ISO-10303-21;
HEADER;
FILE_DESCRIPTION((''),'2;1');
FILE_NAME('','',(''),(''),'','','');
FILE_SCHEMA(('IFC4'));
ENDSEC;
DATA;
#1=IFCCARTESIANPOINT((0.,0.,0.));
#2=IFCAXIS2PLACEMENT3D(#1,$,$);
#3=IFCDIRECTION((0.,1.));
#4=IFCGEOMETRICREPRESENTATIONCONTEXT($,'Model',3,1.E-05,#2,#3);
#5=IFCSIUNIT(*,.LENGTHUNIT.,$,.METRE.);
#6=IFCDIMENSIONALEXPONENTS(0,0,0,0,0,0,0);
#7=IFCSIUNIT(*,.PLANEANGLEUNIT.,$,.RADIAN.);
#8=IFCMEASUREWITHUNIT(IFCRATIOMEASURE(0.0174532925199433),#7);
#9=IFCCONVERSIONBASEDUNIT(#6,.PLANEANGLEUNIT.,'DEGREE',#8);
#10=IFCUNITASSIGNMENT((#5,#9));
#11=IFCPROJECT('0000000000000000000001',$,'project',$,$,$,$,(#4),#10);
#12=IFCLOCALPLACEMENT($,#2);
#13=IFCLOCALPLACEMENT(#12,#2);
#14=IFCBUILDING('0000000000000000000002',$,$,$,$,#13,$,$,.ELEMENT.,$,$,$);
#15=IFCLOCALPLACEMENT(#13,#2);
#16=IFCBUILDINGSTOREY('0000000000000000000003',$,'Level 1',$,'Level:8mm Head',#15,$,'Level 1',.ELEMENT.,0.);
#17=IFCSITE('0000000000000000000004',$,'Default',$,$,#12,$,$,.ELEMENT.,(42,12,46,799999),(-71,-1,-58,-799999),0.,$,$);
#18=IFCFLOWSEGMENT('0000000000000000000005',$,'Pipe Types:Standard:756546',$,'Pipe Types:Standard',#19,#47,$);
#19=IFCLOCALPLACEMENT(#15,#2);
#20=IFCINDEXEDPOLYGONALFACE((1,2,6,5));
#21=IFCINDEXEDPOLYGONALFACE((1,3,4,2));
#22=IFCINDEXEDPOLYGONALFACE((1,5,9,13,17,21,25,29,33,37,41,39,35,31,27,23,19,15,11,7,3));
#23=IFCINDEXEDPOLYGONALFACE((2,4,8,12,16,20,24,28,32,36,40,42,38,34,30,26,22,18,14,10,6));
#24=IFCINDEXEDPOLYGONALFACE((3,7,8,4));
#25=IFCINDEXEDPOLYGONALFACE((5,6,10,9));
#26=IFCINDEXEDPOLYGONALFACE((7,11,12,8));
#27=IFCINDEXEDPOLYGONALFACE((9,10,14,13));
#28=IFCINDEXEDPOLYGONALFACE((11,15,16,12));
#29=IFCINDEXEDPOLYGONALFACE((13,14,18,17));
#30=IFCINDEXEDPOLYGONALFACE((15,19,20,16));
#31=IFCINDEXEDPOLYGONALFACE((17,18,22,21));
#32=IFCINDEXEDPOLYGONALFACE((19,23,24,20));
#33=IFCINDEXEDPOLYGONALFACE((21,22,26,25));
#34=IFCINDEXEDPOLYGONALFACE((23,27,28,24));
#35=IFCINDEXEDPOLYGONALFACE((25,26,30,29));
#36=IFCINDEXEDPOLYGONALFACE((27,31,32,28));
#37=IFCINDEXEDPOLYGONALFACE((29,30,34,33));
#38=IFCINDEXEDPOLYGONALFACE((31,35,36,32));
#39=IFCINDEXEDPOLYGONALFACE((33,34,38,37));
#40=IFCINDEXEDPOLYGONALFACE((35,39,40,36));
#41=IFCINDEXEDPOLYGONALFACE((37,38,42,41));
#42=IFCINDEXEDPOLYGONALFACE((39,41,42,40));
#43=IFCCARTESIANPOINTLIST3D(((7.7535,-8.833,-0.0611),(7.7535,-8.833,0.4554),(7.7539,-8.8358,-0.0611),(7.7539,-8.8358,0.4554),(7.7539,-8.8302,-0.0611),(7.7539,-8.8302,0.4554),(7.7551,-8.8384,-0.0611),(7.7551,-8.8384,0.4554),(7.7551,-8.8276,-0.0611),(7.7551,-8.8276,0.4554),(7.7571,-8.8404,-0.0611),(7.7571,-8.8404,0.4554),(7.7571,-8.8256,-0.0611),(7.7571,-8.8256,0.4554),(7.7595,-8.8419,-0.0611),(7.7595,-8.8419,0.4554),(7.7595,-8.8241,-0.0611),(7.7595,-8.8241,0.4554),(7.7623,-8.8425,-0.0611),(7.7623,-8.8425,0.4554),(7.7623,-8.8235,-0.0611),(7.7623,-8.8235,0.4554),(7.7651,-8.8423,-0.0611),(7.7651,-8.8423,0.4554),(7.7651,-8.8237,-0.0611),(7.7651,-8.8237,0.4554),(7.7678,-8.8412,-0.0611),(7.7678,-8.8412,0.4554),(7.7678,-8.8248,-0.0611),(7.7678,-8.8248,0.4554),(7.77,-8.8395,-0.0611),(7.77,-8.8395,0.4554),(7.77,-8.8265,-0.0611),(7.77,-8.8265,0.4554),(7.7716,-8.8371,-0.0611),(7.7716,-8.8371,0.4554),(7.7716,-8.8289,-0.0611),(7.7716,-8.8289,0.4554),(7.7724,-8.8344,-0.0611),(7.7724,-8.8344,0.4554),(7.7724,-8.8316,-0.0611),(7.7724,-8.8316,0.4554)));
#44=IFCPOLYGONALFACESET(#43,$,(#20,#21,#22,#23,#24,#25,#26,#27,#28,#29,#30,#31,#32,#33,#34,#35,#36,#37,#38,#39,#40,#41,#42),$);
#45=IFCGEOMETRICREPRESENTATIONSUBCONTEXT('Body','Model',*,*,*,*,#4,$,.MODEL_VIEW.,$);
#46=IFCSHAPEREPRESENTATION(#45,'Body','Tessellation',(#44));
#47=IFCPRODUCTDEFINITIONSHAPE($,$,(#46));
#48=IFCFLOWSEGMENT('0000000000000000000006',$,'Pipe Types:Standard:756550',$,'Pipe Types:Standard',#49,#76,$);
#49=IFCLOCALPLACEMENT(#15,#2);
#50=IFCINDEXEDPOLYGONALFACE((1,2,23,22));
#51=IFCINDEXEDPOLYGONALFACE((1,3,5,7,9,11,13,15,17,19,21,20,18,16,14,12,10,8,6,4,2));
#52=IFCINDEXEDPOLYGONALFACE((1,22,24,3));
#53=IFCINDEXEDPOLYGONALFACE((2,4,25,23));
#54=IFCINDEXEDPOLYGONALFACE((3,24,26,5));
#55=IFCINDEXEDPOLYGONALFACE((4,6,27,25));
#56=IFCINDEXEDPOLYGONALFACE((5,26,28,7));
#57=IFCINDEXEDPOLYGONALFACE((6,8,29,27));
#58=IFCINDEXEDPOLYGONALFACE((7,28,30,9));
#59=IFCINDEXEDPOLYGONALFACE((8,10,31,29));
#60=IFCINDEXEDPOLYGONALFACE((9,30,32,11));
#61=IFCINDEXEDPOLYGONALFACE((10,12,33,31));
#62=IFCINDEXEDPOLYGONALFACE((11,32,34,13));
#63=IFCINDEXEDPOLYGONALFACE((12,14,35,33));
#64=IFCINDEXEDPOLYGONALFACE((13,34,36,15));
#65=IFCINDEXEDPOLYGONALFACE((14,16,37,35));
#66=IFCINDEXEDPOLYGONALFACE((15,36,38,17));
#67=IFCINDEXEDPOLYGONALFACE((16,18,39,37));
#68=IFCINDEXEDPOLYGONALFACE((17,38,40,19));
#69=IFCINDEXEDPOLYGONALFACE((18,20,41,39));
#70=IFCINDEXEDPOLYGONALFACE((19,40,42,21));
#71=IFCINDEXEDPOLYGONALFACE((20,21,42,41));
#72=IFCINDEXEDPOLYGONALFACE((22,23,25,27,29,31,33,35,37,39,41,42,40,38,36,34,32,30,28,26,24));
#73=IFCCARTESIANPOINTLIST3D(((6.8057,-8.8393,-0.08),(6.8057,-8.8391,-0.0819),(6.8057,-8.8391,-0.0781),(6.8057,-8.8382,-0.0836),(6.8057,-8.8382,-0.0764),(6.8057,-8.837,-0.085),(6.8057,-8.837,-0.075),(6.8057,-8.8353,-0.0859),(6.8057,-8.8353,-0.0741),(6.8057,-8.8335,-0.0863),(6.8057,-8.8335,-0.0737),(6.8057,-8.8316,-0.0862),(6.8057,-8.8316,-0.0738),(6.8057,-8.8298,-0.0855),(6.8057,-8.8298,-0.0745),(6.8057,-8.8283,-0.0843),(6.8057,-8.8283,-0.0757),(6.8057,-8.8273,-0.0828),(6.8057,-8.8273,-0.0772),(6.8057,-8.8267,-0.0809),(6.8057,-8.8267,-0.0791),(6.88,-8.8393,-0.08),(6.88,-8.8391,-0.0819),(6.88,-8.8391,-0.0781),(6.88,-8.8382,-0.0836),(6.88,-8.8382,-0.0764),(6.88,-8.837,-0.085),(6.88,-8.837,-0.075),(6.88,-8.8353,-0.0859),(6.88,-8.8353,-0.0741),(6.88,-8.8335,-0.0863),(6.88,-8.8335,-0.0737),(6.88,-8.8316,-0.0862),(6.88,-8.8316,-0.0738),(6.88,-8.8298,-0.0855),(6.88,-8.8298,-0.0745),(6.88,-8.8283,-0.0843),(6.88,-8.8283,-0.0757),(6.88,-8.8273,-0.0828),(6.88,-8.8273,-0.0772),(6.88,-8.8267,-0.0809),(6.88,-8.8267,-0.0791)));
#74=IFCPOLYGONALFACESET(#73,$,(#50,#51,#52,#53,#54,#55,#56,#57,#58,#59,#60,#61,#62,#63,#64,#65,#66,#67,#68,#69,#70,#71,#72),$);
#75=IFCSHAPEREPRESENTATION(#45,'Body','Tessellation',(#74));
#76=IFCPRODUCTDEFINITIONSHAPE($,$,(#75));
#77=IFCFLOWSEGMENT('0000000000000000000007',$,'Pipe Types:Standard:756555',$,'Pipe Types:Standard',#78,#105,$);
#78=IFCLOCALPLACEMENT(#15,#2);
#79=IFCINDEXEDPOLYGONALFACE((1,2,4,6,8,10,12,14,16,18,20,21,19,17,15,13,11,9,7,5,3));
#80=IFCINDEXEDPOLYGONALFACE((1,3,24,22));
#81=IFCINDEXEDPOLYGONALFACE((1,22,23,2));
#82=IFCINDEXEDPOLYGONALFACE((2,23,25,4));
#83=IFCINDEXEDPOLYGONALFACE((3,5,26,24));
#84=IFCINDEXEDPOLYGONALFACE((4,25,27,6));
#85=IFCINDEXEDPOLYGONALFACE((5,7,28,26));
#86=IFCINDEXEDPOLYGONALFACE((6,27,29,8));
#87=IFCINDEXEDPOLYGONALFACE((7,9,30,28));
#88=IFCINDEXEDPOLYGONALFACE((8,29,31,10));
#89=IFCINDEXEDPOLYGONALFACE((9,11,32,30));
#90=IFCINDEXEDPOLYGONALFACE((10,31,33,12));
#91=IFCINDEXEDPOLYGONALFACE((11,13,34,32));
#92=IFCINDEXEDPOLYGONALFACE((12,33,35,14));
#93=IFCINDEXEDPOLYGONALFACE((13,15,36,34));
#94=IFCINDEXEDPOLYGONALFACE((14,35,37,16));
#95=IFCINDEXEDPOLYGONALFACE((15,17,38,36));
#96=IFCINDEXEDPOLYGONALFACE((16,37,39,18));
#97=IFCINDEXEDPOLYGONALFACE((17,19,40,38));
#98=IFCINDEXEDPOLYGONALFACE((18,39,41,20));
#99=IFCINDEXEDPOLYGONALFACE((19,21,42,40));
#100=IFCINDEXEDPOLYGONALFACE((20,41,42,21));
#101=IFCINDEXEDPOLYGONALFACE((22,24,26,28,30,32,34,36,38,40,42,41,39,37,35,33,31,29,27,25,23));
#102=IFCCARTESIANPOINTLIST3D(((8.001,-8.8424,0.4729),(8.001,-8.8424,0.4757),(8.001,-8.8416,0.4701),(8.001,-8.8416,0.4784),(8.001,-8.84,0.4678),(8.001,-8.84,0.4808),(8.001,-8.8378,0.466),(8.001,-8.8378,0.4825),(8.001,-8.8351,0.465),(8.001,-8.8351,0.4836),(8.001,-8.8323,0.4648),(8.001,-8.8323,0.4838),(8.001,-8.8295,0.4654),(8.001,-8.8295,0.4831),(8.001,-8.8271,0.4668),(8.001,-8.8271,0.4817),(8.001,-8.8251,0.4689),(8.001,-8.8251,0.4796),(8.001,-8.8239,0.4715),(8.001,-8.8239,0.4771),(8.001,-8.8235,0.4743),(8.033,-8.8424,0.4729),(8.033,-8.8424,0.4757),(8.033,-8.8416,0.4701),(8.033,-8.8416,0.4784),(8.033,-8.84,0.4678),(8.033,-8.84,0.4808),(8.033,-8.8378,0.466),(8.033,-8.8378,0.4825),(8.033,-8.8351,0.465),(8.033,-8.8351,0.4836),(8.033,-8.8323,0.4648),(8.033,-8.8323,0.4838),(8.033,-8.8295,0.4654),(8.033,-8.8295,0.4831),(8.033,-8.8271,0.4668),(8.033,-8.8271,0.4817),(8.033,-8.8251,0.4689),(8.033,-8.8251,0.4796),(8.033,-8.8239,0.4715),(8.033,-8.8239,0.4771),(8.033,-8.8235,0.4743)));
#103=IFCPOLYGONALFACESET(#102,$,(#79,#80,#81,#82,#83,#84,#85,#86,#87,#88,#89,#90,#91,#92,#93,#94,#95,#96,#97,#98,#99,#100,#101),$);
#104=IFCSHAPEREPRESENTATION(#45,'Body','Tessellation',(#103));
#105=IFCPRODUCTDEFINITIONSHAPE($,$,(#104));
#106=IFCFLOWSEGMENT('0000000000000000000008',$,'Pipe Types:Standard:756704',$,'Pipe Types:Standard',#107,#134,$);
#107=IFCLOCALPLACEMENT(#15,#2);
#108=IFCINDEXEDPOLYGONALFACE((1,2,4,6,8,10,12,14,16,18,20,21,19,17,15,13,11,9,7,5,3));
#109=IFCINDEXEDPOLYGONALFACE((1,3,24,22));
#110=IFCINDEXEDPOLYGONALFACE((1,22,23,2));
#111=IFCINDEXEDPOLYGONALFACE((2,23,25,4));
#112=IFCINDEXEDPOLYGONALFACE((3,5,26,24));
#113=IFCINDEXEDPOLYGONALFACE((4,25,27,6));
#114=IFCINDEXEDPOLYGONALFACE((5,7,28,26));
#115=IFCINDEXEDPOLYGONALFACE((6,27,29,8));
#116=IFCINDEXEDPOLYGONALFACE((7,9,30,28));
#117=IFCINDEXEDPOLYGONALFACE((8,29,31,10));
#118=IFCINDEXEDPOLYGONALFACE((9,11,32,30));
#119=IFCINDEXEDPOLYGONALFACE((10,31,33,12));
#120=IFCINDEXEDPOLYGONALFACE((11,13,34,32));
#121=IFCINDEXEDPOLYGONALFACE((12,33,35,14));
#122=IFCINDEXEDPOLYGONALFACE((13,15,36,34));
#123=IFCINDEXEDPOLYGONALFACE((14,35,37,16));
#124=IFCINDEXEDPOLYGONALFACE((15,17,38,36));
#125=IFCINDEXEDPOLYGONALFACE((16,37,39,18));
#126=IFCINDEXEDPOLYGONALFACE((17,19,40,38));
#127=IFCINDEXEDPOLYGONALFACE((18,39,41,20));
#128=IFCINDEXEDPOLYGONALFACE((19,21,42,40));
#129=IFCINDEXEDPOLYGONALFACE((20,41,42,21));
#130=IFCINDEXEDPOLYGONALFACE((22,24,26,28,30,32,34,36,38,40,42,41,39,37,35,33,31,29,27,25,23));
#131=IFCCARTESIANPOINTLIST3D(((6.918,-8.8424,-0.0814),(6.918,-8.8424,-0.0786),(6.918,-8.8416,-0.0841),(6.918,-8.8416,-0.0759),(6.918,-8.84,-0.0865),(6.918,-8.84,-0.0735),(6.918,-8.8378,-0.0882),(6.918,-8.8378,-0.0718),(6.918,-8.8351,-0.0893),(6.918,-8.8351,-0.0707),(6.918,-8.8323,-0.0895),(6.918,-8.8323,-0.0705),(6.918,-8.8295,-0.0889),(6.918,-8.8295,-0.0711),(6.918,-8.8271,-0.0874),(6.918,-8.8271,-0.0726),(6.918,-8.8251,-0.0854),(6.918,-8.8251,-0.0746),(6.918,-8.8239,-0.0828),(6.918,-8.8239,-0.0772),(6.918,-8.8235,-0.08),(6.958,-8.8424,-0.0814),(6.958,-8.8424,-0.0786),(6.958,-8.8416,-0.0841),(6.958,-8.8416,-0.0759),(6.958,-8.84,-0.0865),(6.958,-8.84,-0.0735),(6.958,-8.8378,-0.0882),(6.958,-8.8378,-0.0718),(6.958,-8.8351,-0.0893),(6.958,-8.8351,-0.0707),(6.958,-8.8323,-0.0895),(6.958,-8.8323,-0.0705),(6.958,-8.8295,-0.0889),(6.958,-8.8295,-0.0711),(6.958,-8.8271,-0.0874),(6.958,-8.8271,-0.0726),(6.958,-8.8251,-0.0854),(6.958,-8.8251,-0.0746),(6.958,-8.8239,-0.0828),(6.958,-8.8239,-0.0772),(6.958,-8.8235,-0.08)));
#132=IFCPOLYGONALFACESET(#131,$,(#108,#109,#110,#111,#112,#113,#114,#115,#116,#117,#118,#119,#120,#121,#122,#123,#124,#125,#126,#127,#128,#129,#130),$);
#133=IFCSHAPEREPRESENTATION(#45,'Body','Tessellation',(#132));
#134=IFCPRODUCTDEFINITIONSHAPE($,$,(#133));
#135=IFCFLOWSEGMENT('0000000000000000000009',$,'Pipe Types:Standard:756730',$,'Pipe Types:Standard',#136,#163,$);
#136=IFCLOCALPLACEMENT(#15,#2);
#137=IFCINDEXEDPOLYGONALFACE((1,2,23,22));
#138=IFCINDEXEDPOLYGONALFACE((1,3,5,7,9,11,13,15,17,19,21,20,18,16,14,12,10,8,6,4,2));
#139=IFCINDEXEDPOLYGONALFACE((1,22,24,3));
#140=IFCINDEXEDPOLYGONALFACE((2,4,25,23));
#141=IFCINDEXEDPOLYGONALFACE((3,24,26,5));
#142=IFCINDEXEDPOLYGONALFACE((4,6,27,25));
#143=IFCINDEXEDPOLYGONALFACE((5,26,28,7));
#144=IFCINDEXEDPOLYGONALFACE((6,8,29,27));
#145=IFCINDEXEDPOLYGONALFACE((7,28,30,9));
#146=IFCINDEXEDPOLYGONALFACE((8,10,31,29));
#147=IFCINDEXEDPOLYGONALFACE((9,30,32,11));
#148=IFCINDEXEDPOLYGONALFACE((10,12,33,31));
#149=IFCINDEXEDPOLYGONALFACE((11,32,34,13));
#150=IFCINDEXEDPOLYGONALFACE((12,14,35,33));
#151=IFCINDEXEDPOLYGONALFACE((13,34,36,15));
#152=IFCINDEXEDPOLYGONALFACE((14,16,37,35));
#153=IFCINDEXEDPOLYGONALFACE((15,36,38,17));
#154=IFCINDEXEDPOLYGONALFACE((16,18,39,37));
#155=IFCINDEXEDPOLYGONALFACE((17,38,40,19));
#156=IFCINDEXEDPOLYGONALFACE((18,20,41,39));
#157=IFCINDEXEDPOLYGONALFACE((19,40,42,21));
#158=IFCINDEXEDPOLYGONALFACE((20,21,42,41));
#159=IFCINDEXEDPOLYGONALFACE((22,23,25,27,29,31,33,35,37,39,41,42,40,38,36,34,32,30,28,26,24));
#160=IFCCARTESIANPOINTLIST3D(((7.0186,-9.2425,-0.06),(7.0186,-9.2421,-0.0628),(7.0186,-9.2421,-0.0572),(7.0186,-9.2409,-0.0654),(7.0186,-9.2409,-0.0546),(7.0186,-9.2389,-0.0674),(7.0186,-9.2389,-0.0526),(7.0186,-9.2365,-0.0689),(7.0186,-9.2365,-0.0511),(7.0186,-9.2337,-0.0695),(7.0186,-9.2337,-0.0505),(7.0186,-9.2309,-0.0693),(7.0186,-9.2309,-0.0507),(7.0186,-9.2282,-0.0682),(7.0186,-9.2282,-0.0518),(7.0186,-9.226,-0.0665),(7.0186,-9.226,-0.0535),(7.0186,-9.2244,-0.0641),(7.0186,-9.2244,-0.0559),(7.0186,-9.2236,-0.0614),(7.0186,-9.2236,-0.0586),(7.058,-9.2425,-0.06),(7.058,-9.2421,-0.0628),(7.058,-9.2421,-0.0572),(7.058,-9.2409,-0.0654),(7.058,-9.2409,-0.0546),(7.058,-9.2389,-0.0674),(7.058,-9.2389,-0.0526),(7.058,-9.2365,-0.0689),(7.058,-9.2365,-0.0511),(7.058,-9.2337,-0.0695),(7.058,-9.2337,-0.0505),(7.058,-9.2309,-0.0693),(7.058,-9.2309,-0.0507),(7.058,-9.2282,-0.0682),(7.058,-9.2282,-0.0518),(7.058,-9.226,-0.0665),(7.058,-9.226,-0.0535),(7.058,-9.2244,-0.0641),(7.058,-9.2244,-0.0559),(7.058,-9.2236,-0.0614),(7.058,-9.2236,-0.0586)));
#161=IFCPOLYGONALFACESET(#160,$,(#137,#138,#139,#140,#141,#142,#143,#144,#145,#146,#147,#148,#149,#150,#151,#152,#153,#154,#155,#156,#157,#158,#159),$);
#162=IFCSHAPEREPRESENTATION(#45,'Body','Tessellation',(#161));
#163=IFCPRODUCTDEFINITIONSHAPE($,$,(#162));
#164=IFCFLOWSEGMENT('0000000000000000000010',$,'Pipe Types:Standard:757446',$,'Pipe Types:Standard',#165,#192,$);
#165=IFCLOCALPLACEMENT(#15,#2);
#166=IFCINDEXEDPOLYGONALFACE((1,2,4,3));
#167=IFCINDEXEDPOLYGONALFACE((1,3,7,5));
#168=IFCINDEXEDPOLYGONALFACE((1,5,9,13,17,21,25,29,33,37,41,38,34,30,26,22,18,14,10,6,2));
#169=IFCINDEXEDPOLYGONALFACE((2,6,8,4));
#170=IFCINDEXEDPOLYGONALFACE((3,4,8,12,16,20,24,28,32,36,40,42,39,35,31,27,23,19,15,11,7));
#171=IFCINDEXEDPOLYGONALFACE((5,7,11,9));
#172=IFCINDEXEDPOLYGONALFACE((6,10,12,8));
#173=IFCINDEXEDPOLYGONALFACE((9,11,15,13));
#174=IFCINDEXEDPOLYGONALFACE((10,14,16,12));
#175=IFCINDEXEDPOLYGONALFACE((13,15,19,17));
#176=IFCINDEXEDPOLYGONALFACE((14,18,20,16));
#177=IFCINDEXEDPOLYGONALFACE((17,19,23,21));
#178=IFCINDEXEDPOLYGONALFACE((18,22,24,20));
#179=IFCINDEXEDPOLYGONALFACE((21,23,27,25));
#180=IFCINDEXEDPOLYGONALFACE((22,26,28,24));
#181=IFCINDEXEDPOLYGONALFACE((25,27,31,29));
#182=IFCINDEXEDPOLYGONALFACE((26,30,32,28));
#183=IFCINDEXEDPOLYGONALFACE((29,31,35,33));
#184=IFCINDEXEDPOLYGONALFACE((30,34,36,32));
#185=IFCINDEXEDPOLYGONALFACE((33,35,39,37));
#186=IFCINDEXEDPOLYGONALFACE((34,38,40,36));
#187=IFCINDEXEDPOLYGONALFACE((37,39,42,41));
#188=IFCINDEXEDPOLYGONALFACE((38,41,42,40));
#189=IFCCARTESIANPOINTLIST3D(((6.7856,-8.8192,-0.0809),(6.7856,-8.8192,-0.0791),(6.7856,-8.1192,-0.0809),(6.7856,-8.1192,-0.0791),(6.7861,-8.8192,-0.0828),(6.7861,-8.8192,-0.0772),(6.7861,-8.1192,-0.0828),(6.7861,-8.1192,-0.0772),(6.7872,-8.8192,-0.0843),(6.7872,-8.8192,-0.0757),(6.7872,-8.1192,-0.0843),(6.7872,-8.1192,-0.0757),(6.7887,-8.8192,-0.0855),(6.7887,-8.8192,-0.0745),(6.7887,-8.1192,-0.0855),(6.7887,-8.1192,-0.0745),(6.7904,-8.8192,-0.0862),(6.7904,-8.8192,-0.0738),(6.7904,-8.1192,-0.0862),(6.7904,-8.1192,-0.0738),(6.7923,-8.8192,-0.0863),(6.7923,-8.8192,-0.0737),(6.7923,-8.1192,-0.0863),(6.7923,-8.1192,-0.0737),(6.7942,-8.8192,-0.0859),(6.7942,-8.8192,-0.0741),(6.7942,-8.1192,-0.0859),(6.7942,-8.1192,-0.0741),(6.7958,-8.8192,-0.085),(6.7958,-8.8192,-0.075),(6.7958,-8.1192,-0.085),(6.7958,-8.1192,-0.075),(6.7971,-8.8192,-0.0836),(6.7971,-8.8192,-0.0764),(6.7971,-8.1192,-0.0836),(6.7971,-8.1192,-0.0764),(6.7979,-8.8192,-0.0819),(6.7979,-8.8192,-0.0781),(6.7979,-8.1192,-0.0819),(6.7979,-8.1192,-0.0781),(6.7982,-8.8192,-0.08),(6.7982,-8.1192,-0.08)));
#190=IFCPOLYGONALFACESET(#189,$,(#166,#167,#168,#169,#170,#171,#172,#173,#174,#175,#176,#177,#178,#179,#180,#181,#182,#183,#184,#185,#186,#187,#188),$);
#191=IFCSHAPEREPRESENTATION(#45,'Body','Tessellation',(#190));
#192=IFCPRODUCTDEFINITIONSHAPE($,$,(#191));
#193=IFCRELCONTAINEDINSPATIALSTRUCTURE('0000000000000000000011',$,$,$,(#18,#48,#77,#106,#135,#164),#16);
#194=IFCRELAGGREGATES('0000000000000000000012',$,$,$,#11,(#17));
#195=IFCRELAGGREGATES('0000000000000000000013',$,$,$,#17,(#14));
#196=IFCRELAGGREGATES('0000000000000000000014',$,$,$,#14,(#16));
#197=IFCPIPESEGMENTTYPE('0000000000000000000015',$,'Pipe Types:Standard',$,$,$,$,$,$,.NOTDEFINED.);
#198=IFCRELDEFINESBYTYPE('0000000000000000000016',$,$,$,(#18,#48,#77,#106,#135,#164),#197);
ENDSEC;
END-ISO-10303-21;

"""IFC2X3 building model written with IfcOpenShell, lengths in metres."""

from ifc_helpers import new_model, entity, si_unit, converted_unit, direction, frame, frame_2d, origin, origin_2d_with_axis, place, context, subcontext, project, spatial, circle, extrude, type_object, element, save


model = new_model("IFC2X3")

# Units and contexts
model_context = context("Model", 3, precision=1e-05, world=origin(), true_north=direction((0.0, 1.0)))
body_context = subcontext(model_context, "Body", "Model", "MODEL_VIEW")
ifc_project = project(units=[si_unit("LENGTHUNIT", "METRE"), converted_unit("PLANEANGLEUNIT", "DEGREE", entity("IfcRatioMeasure", 0.0174532925199433), si_unit("PLANEANGLEUNIT", "RADIAN"), dimensions=[0, 0, 0, 0, 0, 0, 0])], contexts=[model_context])

# Site, building, storey
site_placement = place(None, origin())
site = spatial("IfcSite", under=ifc_project, at=site_placement, Name="Default", CompositionType="ELEMENT", RefLatitude=(42, 12, 46, 799999), RefLongitude=(-71, -1, -58, -799999), RefElevation=0.0)
building_placement = place(site_placement, origin())
building = spatial("IfcBuilding", under=site, at=building_placement, CompositionType="ELEMENT")
storey_placement = place(building_placement, origin())
storey = spatial("IfcBuildingStorey", under=building, at=storey_placement, Name="Level 1", ObjectType="Level:8mm Head", LongName="Level 1", CompositionType="ELEMENT", Elevation=0.0)

# Flow segments
pipe_segment_type = type_object("IfcPipeSegmentType", Name="Pipe Types:Standard", PredefinedType="NOTDEFINED")
flow_segment_1_placement = place(storey_placement, origin())
element("IfcFlowSegment", 1, at=flow_segment_1_placement, inside=storey, type_object=pipe_segment_type, Name="Pipe Types:Standard:756546", ObjectType="Pipe Types:Standard", context=body_context, shape_type="SweptSolid", body=[
    extrude(circle(Radius=0.0095, at=origin_2d_with_axis()), frame((7.763, -8.833, -0.0611), z_axis=(0.0, 0.0, 1.0), x_axis=(-1.0, 0.0, 0.0)), (0.0, 0.0, 1.0), 0.5165),
])
flow_segment_2_placement = place(storey_placement, origin())
element("IfcFlowSegment", 2, at=flow_segment_2_placement, inside=storey, type_object=pipe_segment_type, Name="Pipe Types:Standard:756550", ObjectType="Pipe Types:Standard", context=body_context, shape_type="SweptSolid", body=[
    extrude(circle(Radius=0.0063, at=origin_2d_with_axis()), frame((6.8057, -8.833, -0.08), z_axis=(1.0, 0.0, 0.0), x_axis=(0.0, -1.0, 0.0)), (0.0, 0.0, 1.0), 0.0743),
])
flow_segment_3_placement = place(storey_placement, origin())
element("IfcFlowSegment", 3, at=flow_segment_3_placement, inside=storey, type_object=pipe_segment_type, Name="Pipe Types:Standard:756555", ObjectType="Pipe Types:Standard", context=body_context, shape_type="SweptSolid", body=[
    extrude(circle(Radius=0.0095, at=origin_2d_with_axis()), frame((8.001, -8.833, 0.4743), z_axis=(1.0, 0.0, 0.0), x_axis=(0.0, 1.0, 0.0)), (0.0, 0.0, 1.0), 0.032),
])
flow_segment_4_placement = place(storey_placement, origin())
element("IfcFlowSegment", 4, at=flow_segment_4_placement, inside=storey, type_object=pipe_segment_type, Name="Pipe Types:Standard:756704", ObjectType="Pipe Types:Standard", context=body_context, shape_type="SweptSolid", body=[
    extrude(circle(Radius=0.0095, at=frame_2d((0.0, 0.0), x_axis=(1.0, 0.0))), frame((6.918, -8.833, -0.08), z_axis=(1.0, 0.0, 0.0), x_axis=(0.0, 1.0, 0.0)), (0.0, 0.0, 1.0), 0.04),
])
flow_segment_5_placement = place(storey_placement, origin())
element("IfcFlowSegment", 5, at=flow_segment_5_placement, inside=storey, type_object=pipe_segment_type, Name="Pipe Types:Standard:756730", ObjectType="Pipe Types:Standard", context=body_context, shape_type="SweptSolid", body=[
    extrude(circle(Radius=0.0095, at=frame_2d((0.0, 0.0), x_axis=(1.0, 0.0))), frame((7.0186, -9.233, -0.06), z_axis=(1.0, 0.0, 0.0), x_axis=(0.0, -1.0, 0.0)), (0.0, 0.0, 1.0), 0.0394),
])
flow_segment_6_placement = place(storey_placement, origin())
element("IfcFlowSegment", 6, at=flow_segment_6_placement, inside=storey, type_object=pipe_segment_type, Name="Pipe Types:Standard:757446", ObjectType="Pipe Types:Standard", context=body_context, shape_type="SweptSolid", body=[
    extrude(circle(Radius=0.0063, at=origin_2d_with_axis()), frame((6.7918, -8.8192, -0.08), z_axis=(0.0, 1.0, 0.0), x_axis=(1.0, 0.0, 0.0)), (0.0, 0.0, 1.0), 0.6999),
])

save(model, "model.ifc")
